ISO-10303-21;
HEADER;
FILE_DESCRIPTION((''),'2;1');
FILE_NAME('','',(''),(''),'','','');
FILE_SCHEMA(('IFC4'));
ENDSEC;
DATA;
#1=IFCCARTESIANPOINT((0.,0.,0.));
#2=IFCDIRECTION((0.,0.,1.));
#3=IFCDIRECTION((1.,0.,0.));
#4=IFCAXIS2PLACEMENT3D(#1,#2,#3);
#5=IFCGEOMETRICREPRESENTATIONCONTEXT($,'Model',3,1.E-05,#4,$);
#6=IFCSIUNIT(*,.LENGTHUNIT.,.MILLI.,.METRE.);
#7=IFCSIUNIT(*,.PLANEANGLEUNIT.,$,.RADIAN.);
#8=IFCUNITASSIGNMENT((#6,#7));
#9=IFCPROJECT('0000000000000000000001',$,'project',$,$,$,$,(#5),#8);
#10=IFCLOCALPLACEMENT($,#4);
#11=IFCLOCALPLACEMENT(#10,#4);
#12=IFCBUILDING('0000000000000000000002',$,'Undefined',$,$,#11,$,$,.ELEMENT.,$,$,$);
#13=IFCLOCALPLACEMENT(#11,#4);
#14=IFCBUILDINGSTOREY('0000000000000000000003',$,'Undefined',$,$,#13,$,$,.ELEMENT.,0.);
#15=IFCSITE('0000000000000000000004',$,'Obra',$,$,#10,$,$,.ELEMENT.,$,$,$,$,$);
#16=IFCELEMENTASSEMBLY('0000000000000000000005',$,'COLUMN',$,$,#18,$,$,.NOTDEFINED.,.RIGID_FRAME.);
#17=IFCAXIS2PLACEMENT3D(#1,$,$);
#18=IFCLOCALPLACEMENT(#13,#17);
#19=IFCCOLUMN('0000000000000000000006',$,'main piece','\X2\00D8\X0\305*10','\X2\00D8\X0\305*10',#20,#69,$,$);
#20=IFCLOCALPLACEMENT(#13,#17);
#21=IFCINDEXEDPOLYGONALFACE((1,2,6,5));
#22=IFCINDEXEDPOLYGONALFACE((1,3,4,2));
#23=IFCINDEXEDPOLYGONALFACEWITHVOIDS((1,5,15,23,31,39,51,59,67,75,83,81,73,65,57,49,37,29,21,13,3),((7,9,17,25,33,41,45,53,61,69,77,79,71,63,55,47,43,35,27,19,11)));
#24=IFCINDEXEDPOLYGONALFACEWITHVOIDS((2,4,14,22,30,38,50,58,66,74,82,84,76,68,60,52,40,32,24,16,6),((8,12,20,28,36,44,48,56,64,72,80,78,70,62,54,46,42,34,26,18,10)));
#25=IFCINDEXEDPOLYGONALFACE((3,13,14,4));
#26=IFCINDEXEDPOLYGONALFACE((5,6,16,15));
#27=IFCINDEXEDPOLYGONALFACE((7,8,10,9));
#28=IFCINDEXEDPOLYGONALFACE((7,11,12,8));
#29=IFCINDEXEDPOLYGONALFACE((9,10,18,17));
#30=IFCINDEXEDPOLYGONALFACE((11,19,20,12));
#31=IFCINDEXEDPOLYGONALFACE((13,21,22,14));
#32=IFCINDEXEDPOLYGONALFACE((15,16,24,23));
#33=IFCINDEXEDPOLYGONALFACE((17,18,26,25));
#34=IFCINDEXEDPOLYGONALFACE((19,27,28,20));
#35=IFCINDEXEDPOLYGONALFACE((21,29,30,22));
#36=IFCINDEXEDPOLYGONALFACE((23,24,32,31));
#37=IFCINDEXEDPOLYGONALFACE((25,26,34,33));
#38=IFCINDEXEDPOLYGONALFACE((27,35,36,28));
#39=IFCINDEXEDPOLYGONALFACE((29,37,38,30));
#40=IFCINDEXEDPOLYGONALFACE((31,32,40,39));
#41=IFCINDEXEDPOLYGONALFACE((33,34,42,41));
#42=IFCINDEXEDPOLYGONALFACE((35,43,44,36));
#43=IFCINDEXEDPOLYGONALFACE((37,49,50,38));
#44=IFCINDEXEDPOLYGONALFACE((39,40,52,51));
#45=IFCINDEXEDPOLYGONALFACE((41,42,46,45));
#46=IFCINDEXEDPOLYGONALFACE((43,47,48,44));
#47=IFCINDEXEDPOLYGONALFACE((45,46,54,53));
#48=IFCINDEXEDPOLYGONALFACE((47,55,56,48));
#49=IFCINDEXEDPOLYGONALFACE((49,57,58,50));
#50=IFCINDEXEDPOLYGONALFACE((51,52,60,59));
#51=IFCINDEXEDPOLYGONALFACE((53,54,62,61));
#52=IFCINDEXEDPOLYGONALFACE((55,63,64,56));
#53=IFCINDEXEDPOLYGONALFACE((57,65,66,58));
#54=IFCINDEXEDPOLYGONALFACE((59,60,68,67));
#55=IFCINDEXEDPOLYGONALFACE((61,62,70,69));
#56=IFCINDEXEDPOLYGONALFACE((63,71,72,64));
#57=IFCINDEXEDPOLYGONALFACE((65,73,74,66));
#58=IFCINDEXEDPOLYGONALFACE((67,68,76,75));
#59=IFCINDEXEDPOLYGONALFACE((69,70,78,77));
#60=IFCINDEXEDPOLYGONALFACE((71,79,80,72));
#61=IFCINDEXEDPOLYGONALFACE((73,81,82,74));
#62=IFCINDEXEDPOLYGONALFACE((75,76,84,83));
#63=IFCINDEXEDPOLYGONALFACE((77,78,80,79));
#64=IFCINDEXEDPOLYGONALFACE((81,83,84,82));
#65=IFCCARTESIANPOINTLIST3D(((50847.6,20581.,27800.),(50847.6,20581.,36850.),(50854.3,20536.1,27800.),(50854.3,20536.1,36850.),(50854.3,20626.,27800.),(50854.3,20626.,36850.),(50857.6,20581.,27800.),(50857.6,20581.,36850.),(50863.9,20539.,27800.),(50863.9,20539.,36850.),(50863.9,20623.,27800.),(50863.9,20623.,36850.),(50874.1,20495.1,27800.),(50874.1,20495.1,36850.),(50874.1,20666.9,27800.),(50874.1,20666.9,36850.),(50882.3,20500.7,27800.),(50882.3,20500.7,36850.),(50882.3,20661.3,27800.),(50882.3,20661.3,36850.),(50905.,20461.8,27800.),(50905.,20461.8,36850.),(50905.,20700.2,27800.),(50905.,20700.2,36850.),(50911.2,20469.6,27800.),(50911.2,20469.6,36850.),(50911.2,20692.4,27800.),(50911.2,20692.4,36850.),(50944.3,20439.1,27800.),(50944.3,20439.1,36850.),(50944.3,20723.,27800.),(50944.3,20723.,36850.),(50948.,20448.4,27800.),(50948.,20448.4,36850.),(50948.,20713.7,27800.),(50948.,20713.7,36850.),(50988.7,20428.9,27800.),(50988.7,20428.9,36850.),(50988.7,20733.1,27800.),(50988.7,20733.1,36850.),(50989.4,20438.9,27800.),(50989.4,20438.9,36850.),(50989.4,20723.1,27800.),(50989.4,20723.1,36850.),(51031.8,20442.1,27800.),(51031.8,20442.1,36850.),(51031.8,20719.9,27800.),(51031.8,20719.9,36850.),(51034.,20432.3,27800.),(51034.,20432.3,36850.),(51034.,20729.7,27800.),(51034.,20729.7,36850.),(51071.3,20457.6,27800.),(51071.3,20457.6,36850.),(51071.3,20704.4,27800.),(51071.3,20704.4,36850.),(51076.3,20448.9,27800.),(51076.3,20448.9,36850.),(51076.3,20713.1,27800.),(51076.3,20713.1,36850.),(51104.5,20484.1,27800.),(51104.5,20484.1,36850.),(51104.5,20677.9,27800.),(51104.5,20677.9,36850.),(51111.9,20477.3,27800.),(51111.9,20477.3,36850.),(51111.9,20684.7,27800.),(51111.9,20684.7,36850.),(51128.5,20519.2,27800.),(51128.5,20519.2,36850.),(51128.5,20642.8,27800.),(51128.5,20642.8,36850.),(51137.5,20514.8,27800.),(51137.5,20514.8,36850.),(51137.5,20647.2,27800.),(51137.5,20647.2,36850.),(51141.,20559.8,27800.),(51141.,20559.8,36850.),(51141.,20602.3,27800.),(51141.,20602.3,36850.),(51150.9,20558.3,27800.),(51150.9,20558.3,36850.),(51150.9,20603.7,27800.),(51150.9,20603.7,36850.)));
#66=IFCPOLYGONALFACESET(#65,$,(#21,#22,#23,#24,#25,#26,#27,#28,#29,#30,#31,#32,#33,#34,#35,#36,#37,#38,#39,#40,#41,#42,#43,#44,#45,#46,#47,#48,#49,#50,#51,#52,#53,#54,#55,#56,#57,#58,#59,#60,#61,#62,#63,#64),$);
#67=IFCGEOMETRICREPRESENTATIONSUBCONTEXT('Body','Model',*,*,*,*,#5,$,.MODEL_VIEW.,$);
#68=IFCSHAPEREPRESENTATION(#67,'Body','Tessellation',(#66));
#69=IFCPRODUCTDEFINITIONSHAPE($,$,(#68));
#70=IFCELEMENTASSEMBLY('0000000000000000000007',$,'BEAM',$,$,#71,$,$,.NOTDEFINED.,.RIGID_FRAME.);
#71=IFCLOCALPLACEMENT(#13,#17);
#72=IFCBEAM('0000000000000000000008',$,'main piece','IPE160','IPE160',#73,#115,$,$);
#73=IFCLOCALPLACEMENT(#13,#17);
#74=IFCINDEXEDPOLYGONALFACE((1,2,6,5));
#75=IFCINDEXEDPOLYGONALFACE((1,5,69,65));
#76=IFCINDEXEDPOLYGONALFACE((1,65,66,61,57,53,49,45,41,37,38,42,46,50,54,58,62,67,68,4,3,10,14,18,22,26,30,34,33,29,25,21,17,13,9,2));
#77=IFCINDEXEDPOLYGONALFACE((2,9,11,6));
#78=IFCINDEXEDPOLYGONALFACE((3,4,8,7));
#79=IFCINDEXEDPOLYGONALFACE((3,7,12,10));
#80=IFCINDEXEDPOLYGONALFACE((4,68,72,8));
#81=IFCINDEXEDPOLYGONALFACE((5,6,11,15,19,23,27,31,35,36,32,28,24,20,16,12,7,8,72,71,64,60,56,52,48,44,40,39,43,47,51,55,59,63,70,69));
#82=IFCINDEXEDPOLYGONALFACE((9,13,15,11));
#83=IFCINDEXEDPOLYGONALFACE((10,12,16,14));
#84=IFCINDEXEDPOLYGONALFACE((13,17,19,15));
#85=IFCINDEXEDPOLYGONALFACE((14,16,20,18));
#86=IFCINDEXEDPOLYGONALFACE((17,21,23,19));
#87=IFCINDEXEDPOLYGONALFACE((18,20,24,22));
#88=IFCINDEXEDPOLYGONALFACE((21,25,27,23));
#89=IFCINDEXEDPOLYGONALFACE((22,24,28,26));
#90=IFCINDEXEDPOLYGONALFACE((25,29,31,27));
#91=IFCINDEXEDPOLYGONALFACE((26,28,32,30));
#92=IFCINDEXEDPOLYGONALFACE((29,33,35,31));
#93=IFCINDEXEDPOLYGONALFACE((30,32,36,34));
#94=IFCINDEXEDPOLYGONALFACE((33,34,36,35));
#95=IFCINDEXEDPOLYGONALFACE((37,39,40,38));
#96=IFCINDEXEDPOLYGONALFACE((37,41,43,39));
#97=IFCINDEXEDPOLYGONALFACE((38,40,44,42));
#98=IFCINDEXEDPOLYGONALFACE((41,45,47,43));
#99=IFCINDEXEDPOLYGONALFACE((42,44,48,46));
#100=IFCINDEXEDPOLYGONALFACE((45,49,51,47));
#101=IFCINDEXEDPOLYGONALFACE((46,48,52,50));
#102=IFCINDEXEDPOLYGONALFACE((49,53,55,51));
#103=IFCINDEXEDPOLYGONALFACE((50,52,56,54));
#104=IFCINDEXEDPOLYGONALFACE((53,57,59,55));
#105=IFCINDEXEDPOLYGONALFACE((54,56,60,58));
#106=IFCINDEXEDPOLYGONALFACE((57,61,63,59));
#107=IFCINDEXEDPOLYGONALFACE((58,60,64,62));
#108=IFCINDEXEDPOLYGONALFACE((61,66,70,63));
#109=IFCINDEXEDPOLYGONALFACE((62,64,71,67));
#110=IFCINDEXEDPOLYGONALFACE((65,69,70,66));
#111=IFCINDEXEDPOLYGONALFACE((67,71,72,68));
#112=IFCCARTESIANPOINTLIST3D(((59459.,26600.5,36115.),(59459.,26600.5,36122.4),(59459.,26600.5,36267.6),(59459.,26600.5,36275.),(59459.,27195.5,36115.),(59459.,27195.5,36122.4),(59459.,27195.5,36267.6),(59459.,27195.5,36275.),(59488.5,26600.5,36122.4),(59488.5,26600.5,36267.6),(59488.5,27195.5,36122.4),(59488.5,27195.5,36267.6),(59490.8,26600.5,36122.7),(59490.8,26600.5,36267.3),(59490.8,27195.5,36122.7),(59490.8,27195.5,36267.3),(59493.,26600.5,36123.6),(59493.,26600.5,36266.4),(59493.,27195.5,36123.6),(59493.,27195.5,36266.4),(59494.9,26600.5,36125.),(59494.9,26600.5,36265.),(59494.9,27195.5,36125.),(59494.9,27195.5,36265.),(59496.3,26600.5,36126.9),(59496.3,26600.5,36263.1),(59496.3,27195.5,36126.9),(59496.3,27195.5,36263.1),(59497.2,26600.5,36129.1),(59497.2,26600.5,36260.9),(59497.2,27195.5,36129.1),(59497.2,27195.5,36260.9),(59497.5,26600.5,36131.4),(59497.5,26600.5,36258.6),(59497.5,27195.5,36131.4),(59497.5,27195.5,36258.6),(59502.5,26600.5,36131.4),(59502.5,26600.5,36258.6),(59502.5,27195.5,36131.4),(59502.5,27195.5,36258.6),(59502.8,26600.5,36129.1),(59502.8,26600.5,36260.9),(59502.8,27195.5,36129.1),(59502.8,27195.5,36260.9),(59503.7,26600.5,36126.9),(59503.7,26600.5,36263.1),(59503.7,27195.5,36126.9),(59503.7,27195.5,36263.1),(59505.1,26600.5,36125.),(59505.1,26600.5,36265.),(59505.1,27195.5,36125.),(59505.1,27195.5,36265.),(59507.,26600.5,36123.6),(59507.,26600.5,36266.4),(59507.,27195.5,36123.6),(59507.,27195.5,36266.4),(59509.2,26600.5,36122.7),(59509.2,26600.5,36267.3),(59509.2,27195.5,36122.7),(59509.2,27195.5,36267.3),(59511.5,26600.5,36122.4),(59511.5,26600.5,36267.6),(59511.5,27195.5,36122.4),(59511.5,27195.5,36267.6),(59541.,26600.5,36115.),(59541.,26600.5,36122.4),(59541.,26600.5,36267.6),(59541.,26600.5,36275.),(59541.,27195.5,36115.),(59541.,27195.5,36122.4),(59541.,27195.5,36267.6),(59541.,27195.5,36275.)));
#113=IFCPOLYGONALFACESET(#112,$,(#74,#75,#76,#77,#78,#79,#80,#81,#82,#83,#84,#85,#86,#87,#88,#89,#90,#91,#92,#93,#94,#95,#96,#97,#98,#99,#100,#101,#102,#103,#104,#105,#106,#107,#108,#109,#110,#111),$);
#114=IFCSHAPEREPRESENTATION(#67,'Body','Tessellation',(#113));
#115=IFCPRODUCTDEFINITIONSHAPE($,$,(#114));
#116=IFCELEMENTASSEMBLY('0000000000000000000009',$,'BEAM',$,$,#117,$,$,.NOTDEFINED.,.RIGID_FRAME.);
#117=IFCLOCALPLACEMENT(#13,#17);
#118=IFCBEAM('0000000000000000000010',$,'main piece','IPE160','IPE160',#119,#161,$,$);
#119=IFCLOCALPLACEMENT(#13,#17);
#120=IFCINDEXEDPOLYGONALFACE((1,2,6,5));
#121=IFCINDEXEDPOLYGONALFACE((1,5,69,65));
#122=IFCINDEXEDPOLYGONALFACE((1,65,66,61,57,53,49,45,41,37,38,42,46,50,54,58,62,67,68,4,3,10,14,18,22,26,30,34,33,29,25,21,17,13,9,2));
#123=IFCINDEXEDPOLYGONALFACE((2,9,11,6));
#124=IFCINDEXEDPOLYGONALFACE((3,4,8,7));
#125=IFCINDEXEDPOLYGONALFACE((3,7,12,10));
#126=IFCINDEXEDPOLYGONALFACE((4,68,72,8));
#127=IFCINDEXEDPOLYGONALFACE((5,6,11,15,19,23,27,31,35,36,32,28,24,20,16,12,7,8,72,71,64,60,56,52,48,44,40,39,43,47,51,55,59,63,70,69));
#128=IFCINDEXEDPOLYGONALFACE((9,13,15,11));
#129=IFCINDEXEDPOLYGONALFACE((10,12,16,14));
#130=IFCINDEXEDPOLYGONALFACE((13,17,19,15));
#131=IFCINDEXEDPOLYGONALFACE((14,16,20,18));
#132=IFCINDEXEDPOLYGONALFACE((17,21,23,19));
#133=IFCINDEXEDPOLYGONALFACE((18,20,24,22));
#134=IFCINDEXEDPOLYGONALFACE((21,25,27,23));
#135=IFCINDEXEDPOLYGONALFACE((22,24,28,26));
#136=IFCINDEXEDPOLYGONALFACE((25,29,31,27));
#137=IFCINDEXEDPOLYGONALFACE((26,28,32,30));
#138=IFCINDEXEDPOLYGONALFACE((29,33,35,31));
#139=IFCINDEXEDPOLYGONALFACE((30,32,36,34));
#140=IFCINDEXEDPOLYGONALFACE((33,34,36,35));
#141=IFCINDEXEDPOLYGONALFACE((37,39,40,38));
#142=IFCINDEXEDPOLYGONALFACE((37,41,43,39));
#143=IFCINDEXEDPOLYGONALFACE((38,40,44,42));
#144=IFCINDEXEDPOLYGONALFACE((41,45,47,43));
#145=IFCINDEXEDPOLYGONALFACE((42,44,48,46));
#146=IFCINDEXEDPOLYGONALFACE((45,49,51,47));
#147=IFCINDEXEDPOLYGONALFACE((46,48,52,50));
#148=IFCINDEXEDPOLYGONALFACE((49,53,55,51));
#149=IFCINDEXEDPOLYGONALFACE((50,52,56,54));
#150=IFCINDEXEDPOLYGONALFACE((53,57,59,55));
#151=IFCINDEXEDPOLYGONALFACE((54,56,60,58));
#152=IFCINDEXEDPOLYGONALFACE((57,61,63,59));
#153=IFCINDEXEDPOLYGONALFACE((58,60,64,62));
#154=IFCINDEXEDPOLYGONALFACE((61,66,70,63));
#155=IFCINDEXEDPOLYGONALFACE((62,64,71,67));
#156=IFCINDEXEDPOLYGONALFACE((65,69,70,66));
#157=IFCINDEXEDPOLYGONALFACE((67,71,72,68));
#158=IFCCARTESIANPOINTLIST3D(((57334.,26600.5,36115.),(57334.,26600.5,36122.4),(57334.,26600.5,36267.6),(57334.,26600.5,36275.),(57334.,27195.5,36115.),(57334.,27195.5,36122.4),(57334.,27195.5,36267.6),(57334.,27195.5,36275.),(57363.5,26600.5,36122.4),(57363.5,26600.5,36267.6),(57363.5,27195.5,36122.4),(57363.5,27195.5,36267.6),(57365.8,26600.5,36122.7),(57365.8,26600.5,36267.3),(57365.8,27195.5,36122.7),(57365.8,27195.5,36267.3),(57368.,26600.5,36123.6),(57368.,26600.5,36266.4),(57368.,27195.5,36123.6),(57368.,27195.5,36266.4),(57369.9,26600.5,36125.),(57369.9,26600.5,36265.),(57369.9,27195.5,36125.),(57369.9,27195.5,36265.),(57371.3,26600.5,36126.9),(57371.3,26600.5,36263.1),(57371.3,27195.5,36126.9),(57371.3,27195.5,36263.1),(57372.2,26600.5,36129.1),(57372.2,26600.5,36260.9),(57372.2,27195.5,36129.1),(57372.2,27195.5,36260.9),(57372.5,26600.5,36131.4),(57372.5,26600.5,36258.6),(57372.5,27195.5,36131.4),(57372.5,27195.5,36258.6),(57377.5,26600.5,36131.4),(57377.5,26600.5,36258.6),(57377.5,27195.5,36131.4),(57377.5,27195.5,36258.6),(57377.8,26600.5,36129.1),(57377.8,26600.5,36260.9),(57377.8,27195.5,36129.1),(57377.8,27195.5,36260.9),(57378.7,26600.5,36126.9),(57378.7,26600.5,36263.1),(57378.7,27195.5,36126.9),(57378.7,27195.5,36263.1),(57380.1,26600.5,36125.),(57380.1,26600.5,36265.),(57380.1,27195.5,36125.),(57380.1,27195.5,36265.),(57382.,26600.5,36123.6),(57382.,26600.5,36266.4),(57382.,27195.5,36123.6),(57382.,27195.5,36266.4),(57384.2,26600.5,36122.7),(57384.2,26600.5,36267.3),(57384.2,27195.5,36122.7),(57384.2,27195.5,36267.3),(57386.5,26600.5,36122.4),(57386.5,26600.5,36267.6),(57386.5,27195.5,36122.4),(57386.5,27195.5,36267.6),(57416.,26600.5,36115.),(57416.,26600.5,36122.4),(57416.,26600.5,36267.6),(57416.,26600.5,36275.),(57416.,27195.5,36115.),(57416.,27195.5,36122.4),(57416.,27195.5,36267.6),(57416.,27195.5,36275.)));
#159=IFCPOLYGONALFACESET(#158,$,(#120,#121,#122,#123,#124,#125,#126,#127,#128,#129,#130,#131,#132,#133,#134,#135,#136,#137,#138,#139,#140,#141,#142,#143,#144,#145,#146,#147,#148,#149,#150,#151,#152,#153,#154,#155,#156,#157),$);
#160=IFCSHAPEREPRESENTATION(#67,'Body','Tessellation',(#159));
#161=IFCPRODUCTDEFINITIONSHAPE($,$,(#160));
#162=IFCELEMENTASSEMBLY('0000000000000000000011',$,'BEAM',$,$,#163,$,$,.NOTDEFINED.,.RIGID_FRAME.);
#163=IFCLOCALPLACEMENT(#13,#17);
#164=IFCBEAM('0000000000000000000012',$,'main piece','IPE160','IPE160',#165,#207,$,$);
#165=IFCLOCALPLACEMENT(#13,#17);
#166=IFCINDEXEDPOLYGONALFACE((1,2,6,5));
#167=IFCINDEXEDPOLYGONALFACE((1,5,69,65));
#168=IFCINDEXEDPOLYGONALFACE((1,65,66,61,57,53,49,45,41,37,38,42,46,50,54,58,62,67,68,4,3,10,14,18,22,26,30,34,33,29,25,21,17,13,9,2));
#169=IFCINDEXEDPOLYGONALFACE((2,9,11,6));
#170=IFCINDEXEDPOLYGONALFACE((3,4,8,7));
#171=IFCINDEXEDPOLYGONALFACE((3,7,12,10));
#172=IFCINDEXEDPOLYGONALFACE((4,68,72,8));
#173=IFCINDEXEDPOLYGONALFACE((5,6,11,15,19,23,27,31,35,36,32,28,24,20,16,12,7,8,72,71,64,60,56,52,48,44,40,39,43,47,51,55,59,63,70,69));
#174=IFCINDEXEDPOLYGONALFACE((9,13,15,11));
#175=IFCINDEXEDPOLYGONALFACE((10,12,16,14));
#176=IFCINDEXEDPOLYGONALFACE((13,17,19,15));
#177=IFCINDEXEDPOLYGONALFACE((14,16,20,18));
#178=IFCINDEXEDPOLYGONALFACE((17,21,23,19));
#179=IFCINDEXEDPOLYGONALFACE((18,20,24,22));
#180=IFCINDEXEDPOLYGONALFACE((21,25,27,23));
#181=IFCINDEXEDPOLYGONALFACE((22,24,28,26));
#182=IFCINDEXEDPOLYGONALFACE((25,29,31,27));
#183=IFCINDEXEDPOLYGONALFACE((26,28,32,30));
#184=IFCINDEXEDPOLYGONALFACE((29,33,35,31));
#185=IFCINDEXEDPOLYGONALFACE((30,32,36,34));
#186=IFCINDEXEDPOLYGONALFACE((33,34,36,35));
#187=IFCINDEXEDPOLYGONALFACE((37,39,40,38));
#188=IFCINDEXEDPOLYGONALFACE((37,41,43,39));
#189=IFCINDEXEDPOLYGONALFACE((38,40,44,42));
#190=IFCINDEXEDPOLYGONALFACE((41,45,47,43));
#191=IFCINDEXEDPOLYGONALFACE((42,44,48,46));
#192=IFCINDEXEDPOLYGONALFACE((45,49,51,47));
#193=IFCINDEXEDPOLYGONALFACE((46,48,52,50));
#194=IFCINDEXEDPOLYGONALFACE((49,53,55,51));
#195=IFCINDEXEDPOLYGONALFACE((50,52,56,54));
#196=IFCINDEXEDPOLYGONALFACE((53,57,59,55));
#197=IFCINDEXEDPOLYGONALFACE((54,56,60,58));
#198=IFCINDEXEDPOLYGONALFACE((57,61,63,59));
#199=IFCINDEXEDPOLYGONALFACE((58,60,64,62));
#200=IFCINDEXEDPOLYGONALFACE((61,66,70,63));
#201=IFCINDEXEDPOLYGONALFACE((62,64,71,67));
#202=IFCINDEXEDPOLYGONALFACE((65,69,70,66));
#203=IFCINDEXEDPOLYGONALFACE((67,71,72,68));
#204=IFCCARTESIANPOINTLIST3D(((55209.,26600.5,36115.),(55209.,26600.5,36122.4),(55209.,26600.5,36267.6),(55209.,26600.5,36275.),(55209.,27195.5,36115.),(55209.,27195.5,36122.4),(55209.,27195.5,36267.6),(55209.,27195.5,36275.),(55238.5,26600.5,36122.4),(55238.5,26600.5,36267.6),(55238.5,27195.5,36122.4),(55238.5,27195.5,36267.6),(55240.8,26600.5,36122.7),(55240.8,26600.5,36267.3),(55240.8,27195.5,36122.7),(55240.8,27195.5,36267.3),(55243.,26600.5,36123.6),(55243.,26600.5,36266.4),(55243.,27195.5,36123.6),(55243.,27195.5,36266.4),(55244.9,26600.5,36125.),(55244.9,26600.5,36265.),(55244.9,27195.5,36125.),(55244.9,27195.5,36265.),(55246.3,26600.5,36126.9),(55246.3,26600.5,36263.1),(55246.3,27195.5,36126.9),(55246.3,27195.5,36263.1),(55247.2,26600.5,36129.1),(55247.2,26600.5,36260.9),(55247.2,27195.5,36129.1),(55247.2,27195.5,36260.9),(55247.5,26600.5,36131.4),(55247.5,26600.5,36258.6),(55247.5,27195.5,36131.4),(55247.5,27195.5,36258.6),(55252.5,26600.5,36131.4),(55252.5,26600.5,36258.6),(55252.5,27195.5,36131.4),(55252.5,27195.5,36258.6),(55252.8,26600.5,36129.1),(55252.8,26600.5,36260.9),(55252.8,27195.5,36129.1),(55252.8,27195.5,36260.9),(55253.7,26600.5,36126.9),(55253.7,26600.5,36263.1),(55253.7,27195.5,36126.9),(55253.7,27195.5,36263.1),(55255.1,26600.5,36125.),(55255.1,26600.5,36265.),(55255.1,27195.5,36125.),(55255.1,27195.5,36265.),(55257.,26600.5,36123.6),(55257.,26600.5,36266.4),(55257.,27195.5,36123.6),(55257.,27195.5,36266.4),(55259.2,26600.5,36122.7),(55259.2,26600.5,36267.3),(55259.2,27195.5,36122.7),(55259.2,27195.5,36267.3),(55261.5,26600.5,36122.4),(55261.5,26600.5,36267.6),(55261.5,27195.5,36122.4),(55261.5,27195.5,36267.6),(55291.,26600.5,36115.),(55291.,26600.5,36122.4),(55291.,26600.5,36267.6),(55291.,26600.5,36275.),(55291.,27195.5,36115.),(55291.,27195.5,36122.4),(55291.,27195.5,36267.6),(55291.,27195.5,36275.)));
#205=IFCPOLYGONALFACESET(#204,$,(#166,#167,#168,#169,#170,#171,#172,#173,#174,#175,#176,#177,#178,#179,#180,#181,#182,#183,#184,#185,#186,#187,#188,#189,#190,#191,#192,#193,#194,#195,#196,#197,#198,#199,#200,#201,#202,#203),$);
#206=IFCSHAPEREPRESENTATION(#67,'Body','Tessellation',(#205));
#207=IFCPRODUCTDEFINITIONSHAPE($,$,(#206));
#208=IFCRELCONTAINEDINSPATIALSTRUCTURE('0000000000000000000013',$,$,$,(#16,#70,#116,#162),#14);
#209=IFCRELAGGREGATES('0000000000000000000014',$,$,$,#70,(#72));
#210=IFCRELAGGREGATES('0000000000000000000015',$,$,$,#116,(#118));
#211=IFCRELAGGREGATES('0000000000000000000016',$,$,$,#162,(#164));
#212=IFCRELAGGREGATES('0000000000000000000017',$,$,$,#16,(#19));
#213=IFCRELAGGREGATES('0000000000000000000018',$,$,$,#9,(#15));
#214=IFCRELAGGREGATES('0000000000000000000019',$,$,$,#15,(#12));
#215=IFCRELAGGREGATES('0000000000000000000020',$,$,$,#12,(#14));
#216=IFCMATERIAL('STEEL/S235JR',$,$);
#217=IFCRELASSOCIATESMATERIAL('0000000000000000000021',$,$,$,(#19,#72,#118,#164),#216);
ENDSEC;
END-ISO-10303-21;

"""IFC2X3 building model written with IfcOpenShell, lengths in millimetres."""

from ifc_helpers import new_model, si_unit, frame, origin_with_axes, origin_2d_with_axis, place, context, subcontext, project, spatial, hollow_circle, i_section, extrude, material, element, aggregate, save


model = new_model("IFC2X3")

# Units and contexts
model_context = context("Model", 3, precision=1e-05, world=origin_with_axes())
body_context = subcontext(model_context, "Body", "Model", "MODEL_VIEW")
ifc_project = project(units=[si_unit("LENGTHUNIT", "METRE", prefix="MILLI"), si_unit("PLANEANGLEUNIT", "RADIAN")], contexts=[model_context])

# Site, building, storey
site_placement = place(None, origin_with_axes())
site = spatial("IfcSite", under=ifc_project, at=site_placement, Name="Obra", CompositionType="ELEMENT")
building_placement = place(site_placement, origin_with_axes())
building = spatial("IfcBuilding", under=site, at=building_placement, Name="Undefined", CompositionType="ELEMENT")
storey_placement = place(building_placement, origin_with_axes())
storey = spatial("IfcBuildingStorey", under=building, at=storey_placement, Name="Undefined", CompositionType="ELEMENT", Elevation=0.0)

# Element assembly, column
ifc_material_1 = material(Name="STEEL/S235JR")
assembly_1_placement = place(storey_placement, origin_with_axes())
assembly_1 = element("IfcElementAssembly", 1, at=assembly_1_placement, inside=storey, Name="COLUMN", AssemblyPlace="NOTDEFINED", PredefinedType="RIGID_FRAME")
column_1_placement = place(assembly_1_placement, frame((51000.1, 20581.0, 27800.0), z_axis=(0.0, 0.0, 1.0), x_axis=(0.0, 1.0, 0.0)))
column_1 = element("IfcColumn", 2, at=column_1_placement, material=ifc_material_1, Name="main piece", Description="Ø305*10", ObjectType="Ø305*10", context=body_context, shape_type="SweptSolid", body=[
    extrude(hollow_circle(Radius=152.5, WallThickness=10.0, at=origin_2d_with_axis()), frame((0.0, 0.0, 9050.0), z_axis=(0.0, 0.0, -1.0), x_axis=(0.0, 1.0, 0.0)), (0.0, 0.0, 1.0), 9050.0),
])

# Element assemblies, beams
assembly_2_placement = place(storey_placement, origin_with_axes())
assembly_2 = element("IfcElementAssembly", 3, at=assembly_2_placement, inside=storey, Name="BEAM", AssemblyPlace="NOTDEFINED", PredefinedType="RIGID_FRAME")
beam_1_placement = place(assembly_2_placement, frame((59500.0, 26600.5, 36195.0), z_axis=(0.0, 0.0, 1.0), x_axis=(0.0, 1.0, 0.0)))
beam_1 = element("IfcBeam", 4, at=beam_1_placement, material=ifc_material_1, Name="main piece", Description="IPE160", ObjectType="IPE160", context=body_context, shape_type="SweptSolid", body=[
    extrude(i_section(OverallWidth=82.0, OverallDepth=160.0, WebThickness=5.0, FlangeThickness=7.4, FilletRadius=9.0, at=origin_2d_with_axis()), frame((595.0, 0.0, 0.0), z_axis=(-1.0, 0.0, 0.0), x_axis=(0.0, -1.0, 0.0)), (0.0, 0.0, 1.0), 595.0),
])
aggregate(assembly_2, [beam_1])
assembly_3_placement = place(storey_placement, origin_with_axes())
assembly_3 = element("IfcElementAssembly", 5, at=assembly_3_placement, inside=storey, Name="BEAM", AssemblyPlace="NOTDEFINED", PredefinedType="RIGID_FRAME")
beam_2_placement = place(assembly_3_placement, frame((57375.0, 27195.5, 36195.0), z_axis=(0.0, 0.0, 1.0), x_axis=(0.0, -1.0, 0.0)))
beam_2 = element("IfcBeam", 6, at=beam_2_placement, material=ifc_material_1, Name="main piece", Description="IPE160", ObjectType="IPE160", context=body_context, shape_type="SweptSolid", body=[
    extrude(i_section(OverallWidth=82.0, OverallDepth=160.0, WebThickness=5.0, FlangeThickness=7.4, FilletRadius=9.0, at=origin_2d_with_axis()), frame((595.0, 0.0, 0.0), z_axis=(-1.0, 0.0, 0.0), x_axis=(0.0, -1.0, 0.0)), (0.0, 0.0, 1.0), 595.0),
])
aggregate(assembly_3, [beam_2])
assembly_4_placement = place(storey_placement, origin_with_axes())
assembly_4 = element("IfcElementAssembly", 7, at=assembly_4_placement, inside=storey, Name="BEAM", AssemblyPlace="NOTDEFINED", PredefinedType="RIGID_FRAME")
beam_3_placement = place(assembly_4_placement, frame((55250.0, 26600.5, 36195.0), z_axis=(0.0, 0.0, 1.0), x_axis=(0.0, 1.0, 0.0)))
beam_3 = element("IfcBeam", 8, at=beam_3_placement, material=ifc_material_1, Name="main piece", Description="IPE160", ObjectType="IPE160", context=body_context, shape_type="SweptSolid", body=[
    extrude(i_section(OverallWidth=82.0, OverallDepth=160.0, WebThickness=5.0, FlangeThickness=7.4, FilletRadius=9.0, at=origin_2d_with_axis()), frame((595.0, 0.0, 0.0), z_axis=(-1.0, 0.0, 0.0), x_axis=(0.0, -1.0, 0.0)), (0.0, 0.0, 1.0), 595.0),
])
aggregate(assembly_4, [beam_3])

aggregate(assembly_1, [column_1])

save(model, "model.ifc")
